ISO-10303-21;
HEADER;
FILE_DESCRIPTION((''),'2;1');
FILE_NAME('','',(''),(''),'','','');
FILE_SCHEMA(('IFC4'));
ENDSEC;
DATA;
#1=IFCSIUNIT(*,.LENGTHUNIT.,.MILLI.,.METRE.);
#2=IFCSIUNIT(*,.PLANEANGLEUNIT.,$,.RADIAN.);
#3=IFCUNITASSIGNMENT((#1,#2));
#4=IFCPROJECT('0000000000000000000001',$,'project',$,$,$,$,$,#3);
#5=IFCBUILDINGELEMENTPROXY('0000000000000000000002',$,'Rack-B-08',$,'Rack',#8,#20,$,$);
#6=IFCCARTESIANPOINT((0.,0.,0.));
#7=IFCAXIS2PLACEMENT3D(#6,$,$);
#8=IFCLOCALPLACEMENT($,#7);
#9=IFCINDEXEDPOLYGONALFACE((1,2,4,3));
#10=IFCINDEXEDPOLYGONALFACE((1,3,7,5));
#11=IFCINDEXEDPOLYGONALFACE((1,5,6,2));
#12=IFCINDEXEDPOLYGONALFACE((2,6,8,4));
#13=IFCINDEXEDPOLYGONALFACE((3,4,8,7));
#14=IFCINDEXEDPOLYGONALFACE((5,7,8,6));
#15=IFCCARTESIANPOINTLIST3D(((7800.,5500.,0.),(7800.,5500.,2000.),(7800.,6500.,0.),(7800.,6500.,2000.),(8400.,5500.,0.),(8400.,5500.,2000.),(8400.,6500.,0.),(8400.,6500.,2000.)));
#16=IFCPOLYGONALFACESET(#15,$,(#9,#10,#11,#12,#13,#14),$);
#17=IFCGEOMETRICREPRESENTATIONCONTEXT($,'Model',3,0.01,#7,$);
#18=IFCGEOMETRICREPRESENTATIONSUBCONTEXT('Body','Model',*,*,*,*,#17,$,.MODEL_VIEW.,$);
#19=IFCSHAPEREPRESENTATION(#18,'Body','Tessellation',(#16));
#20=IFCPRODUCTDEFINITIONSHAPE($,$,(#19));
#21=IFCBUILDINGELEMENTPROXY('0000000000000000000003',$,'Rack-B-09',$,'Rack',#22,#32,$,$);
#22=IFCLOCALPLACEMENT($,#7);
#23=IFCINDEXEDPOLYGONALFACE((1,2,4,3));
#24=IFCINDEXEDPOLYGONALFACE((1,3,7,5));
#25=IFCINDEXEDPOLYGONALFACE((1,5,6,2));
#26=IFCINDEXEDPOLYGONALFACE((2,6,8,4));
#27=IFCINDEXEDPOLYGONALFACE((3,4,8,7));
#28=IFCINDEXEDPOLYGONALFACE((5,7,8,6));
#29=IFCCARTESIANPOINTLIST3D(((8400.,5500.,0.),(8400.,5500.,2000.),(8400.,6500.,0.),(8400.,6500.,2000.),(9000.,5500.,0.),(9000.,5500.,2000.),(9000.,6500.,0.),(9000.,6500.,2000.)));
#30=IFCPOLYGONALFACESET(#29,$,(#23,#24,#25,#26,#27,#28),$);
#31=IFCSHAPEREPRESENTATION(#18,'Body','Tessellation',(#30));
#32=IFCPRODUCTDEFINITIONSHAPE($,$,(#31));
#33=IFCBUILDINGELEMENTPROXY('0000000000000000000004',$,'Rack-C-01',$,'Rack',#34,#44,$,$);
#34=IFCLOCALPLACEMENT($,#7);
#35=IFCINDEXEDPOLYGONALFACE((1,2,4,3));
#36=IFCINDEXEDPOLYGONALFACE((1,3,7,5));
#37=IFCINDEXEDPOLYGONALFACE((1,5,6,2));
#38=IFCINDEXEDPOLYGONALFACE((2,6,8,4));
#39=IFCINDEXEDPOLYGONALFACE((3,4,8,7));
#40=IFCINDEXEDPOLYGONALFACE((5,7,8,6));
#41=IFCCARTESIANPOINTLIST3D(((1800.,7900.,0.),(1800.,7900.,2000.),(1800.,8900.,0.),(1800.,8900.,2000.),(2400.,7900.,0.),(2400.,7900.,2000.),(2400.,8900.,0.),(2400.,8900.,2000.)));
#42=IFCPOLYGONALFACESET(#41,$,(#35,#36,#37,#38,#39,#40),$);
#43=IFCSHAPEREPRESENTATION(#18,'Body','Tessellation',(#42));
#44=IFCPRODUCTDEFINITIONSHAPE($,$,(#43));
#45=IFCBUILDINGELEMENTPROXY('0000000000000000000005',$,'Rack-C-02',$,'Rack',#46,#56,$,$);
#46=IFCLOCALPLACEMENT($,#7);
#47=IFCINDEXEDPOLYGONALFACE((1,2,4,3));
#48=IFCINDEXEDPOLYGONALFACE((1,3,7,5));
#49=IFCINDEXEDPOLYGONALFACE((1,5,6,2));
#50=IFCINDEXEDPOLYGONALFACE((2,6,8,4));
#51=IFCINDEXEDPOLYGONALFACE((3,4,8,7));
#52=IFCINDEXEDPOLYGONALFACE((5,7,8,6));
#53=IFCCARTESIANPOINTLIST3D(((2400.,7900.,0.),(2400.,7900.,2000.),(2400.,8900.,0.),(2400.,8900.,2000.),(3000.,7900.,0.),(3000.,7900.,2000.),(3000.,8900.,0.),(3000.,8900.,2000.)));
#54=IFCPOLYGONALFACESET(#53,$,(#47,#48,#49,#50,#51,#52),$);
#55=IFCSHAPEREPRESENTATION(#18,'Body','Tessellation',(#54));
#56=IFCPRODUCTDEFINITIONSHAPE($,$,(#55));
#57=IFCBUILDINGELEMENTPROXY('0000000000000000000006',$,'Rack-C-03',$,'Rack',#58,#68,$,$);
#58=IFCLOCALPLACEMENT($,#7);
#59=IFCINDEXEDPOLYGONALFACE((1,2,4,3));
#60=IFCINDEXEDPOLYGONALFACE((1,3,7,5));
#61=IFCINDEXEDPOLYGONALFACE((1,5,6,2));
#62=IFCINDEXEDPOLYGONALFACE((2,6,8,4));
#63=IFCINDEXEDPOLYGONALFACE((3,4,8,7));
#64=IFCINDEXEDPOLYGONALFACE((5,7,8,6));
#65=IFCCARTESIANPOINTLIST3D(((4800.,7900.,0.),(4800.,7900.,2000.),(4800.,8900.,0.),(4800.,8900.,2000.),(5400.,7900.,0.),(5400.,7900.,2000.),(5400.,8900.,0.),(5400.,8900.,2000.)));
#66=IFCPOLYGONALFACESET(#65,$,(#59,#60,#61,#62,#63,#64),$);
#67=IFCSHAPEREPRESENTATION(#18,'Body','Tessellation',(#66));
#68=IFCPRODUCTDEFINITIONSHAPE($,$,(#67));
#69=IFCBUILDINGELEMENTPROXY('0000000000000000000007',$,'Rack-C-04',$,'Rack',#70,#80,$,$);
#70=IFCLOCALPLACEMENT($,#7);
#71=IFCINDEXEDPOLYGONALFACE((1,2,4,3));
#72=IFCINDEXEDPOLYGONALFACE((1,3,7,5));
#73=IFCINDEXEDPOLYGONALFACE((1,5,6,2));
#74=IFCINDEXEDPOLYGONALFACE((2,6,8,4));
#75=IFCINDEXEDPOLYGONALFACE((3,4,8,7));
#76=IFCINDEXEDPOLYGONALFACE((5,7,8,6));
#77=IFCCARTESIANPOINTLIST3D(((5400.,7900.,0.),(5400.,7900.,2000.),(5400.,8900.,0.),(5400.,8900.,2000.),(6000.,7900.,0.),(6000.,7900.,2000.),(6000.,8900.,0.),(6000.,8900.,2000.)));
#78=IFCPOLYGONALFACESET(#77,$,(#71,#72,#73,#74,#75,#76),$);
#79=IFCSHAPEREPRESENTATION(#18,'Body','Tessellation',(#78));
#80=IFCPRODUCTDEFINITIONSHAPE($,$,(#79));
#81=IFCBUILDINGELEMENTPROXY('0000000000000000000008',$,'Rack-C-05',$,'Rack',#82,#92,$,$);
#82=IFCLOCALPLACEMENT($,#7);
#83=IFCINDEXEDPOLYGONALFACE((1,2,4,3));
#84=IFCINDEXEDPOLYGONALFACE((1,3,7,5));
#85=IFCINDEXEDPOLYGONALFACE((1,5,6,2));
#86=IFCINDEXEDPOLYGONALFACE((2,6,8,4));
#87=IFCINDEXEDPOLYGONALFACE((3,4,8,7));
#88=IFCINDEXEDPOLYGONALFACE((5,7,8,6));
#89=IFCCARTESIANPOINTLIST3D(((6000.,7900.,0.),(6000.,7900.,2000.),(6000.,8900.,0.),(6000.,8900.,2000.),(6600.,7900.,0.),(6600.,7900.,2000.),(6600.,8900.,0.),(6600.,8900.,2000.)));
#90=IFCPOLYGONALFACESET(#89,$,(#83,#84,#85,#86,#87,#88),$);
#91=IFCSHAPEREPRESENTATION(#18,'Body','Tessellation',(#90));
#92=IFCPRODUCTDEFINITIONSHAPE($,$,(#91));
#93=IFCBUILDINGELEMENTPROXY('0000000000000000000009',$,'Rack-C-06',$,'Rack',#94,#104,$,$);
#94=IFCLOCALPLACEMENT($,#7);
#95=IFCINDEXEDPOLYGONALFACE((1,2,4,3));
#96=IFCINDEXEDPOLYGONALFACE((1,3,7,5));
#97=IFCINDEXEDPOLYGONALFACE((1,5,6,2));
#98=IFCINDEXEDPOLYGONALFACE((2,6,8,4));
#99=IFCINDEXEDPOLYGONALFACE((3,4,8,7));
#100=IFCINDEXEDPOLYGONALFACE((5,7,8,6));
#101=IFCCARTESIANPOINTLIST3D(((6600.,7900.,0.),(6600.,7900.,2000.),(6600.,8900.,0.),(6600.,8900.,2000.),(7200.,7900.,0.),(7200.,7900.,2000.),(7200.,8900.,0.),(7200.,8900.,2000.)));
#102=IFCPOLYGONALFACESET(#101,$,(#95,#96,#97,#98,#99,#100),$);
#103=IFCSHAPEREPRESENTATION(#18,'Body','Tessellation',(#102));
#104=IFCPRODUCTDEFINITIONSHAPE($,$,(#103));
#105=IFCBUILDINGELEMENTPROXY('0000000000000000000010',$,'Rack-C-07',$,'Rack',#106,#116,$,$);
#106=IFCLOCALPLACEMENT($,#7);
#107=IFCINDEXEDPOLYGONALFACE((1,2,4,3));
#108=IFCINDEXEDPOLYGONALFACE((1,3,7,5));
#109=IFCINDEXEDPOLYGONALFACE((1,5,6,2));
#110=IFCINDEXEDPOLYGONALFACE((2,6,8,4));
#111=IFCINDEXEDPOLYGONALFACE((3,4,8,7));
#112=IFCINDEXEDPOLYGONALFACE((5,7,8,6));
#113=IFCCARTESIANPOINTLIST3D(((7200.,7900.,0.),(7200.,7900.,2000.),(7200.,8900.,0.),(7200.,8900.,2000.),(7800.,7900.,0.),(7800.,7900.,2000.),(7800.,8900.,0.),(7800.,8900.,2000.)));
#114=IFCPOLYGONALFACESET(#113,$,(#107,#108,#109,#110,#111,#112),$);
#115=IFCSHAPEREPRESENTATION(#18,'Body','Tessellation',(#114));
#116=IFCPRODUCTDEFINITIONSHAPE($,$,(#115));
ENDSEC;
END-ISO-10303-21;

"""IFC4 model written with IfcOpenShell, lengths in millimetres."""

from ifc_helpers import new_model, si_unit, frame, origin, place, context, subcontext, project, rectangle, extrude, element, save


model = new_model("IFC4")

# Units and contexts
model_context = context("Model", 3, precision=0.01, world=origin())
body_context = subcontext(model_context, "Body", "Model", "MODEL_VIEW")
ifc_project = project(units=[si_unit("LENGTHUNIT", "METRE", prefix="MILLI"), si_unit("PLANEANGLEUNIT", "RADIAN")])

# Shared definitions
placement = place(None, origin())

# Building element proxies
for number, where, name in (
    (1, (8100.0, 6000.0, 0.0), "Rack-B-08"),
    (2, (8700.0, 6000.0, 0.0), "Rack-B-09"),
    (3, (2100.0, 8400.0, 0.0), "Rack-C-01"),
    (4, (2700.0, 8400.0, 0.0), "Rack-C-02"),
    (5, (5100.0, 8400.0, 0.0), "Rack-C-03"),
    (6, (5700.0, 8400.0, 0.0), "Rack-C-04"),
    (7, (6300.0, 8400.0, 0.0), "Rack-C-05"),
    (8, (6900.0, 8400.0, 0.0), "Rack-C-06"),
    (9, (7500.0, 8400.0, 0.0), "Rack-C-07"),
):
    element("IfcBuildingElementProxy", number, at=place(placement, frame(where)), Name=name, ObjectType="Rack", context=body_context, shape_type="SweptSolid", body=[
        extrude(rectangle(XDim=600.0, YDim=1000.0), origin(), (0.0, 0.0, 1.0), 2000.0),
    ])

save(model, "model.ifc")
